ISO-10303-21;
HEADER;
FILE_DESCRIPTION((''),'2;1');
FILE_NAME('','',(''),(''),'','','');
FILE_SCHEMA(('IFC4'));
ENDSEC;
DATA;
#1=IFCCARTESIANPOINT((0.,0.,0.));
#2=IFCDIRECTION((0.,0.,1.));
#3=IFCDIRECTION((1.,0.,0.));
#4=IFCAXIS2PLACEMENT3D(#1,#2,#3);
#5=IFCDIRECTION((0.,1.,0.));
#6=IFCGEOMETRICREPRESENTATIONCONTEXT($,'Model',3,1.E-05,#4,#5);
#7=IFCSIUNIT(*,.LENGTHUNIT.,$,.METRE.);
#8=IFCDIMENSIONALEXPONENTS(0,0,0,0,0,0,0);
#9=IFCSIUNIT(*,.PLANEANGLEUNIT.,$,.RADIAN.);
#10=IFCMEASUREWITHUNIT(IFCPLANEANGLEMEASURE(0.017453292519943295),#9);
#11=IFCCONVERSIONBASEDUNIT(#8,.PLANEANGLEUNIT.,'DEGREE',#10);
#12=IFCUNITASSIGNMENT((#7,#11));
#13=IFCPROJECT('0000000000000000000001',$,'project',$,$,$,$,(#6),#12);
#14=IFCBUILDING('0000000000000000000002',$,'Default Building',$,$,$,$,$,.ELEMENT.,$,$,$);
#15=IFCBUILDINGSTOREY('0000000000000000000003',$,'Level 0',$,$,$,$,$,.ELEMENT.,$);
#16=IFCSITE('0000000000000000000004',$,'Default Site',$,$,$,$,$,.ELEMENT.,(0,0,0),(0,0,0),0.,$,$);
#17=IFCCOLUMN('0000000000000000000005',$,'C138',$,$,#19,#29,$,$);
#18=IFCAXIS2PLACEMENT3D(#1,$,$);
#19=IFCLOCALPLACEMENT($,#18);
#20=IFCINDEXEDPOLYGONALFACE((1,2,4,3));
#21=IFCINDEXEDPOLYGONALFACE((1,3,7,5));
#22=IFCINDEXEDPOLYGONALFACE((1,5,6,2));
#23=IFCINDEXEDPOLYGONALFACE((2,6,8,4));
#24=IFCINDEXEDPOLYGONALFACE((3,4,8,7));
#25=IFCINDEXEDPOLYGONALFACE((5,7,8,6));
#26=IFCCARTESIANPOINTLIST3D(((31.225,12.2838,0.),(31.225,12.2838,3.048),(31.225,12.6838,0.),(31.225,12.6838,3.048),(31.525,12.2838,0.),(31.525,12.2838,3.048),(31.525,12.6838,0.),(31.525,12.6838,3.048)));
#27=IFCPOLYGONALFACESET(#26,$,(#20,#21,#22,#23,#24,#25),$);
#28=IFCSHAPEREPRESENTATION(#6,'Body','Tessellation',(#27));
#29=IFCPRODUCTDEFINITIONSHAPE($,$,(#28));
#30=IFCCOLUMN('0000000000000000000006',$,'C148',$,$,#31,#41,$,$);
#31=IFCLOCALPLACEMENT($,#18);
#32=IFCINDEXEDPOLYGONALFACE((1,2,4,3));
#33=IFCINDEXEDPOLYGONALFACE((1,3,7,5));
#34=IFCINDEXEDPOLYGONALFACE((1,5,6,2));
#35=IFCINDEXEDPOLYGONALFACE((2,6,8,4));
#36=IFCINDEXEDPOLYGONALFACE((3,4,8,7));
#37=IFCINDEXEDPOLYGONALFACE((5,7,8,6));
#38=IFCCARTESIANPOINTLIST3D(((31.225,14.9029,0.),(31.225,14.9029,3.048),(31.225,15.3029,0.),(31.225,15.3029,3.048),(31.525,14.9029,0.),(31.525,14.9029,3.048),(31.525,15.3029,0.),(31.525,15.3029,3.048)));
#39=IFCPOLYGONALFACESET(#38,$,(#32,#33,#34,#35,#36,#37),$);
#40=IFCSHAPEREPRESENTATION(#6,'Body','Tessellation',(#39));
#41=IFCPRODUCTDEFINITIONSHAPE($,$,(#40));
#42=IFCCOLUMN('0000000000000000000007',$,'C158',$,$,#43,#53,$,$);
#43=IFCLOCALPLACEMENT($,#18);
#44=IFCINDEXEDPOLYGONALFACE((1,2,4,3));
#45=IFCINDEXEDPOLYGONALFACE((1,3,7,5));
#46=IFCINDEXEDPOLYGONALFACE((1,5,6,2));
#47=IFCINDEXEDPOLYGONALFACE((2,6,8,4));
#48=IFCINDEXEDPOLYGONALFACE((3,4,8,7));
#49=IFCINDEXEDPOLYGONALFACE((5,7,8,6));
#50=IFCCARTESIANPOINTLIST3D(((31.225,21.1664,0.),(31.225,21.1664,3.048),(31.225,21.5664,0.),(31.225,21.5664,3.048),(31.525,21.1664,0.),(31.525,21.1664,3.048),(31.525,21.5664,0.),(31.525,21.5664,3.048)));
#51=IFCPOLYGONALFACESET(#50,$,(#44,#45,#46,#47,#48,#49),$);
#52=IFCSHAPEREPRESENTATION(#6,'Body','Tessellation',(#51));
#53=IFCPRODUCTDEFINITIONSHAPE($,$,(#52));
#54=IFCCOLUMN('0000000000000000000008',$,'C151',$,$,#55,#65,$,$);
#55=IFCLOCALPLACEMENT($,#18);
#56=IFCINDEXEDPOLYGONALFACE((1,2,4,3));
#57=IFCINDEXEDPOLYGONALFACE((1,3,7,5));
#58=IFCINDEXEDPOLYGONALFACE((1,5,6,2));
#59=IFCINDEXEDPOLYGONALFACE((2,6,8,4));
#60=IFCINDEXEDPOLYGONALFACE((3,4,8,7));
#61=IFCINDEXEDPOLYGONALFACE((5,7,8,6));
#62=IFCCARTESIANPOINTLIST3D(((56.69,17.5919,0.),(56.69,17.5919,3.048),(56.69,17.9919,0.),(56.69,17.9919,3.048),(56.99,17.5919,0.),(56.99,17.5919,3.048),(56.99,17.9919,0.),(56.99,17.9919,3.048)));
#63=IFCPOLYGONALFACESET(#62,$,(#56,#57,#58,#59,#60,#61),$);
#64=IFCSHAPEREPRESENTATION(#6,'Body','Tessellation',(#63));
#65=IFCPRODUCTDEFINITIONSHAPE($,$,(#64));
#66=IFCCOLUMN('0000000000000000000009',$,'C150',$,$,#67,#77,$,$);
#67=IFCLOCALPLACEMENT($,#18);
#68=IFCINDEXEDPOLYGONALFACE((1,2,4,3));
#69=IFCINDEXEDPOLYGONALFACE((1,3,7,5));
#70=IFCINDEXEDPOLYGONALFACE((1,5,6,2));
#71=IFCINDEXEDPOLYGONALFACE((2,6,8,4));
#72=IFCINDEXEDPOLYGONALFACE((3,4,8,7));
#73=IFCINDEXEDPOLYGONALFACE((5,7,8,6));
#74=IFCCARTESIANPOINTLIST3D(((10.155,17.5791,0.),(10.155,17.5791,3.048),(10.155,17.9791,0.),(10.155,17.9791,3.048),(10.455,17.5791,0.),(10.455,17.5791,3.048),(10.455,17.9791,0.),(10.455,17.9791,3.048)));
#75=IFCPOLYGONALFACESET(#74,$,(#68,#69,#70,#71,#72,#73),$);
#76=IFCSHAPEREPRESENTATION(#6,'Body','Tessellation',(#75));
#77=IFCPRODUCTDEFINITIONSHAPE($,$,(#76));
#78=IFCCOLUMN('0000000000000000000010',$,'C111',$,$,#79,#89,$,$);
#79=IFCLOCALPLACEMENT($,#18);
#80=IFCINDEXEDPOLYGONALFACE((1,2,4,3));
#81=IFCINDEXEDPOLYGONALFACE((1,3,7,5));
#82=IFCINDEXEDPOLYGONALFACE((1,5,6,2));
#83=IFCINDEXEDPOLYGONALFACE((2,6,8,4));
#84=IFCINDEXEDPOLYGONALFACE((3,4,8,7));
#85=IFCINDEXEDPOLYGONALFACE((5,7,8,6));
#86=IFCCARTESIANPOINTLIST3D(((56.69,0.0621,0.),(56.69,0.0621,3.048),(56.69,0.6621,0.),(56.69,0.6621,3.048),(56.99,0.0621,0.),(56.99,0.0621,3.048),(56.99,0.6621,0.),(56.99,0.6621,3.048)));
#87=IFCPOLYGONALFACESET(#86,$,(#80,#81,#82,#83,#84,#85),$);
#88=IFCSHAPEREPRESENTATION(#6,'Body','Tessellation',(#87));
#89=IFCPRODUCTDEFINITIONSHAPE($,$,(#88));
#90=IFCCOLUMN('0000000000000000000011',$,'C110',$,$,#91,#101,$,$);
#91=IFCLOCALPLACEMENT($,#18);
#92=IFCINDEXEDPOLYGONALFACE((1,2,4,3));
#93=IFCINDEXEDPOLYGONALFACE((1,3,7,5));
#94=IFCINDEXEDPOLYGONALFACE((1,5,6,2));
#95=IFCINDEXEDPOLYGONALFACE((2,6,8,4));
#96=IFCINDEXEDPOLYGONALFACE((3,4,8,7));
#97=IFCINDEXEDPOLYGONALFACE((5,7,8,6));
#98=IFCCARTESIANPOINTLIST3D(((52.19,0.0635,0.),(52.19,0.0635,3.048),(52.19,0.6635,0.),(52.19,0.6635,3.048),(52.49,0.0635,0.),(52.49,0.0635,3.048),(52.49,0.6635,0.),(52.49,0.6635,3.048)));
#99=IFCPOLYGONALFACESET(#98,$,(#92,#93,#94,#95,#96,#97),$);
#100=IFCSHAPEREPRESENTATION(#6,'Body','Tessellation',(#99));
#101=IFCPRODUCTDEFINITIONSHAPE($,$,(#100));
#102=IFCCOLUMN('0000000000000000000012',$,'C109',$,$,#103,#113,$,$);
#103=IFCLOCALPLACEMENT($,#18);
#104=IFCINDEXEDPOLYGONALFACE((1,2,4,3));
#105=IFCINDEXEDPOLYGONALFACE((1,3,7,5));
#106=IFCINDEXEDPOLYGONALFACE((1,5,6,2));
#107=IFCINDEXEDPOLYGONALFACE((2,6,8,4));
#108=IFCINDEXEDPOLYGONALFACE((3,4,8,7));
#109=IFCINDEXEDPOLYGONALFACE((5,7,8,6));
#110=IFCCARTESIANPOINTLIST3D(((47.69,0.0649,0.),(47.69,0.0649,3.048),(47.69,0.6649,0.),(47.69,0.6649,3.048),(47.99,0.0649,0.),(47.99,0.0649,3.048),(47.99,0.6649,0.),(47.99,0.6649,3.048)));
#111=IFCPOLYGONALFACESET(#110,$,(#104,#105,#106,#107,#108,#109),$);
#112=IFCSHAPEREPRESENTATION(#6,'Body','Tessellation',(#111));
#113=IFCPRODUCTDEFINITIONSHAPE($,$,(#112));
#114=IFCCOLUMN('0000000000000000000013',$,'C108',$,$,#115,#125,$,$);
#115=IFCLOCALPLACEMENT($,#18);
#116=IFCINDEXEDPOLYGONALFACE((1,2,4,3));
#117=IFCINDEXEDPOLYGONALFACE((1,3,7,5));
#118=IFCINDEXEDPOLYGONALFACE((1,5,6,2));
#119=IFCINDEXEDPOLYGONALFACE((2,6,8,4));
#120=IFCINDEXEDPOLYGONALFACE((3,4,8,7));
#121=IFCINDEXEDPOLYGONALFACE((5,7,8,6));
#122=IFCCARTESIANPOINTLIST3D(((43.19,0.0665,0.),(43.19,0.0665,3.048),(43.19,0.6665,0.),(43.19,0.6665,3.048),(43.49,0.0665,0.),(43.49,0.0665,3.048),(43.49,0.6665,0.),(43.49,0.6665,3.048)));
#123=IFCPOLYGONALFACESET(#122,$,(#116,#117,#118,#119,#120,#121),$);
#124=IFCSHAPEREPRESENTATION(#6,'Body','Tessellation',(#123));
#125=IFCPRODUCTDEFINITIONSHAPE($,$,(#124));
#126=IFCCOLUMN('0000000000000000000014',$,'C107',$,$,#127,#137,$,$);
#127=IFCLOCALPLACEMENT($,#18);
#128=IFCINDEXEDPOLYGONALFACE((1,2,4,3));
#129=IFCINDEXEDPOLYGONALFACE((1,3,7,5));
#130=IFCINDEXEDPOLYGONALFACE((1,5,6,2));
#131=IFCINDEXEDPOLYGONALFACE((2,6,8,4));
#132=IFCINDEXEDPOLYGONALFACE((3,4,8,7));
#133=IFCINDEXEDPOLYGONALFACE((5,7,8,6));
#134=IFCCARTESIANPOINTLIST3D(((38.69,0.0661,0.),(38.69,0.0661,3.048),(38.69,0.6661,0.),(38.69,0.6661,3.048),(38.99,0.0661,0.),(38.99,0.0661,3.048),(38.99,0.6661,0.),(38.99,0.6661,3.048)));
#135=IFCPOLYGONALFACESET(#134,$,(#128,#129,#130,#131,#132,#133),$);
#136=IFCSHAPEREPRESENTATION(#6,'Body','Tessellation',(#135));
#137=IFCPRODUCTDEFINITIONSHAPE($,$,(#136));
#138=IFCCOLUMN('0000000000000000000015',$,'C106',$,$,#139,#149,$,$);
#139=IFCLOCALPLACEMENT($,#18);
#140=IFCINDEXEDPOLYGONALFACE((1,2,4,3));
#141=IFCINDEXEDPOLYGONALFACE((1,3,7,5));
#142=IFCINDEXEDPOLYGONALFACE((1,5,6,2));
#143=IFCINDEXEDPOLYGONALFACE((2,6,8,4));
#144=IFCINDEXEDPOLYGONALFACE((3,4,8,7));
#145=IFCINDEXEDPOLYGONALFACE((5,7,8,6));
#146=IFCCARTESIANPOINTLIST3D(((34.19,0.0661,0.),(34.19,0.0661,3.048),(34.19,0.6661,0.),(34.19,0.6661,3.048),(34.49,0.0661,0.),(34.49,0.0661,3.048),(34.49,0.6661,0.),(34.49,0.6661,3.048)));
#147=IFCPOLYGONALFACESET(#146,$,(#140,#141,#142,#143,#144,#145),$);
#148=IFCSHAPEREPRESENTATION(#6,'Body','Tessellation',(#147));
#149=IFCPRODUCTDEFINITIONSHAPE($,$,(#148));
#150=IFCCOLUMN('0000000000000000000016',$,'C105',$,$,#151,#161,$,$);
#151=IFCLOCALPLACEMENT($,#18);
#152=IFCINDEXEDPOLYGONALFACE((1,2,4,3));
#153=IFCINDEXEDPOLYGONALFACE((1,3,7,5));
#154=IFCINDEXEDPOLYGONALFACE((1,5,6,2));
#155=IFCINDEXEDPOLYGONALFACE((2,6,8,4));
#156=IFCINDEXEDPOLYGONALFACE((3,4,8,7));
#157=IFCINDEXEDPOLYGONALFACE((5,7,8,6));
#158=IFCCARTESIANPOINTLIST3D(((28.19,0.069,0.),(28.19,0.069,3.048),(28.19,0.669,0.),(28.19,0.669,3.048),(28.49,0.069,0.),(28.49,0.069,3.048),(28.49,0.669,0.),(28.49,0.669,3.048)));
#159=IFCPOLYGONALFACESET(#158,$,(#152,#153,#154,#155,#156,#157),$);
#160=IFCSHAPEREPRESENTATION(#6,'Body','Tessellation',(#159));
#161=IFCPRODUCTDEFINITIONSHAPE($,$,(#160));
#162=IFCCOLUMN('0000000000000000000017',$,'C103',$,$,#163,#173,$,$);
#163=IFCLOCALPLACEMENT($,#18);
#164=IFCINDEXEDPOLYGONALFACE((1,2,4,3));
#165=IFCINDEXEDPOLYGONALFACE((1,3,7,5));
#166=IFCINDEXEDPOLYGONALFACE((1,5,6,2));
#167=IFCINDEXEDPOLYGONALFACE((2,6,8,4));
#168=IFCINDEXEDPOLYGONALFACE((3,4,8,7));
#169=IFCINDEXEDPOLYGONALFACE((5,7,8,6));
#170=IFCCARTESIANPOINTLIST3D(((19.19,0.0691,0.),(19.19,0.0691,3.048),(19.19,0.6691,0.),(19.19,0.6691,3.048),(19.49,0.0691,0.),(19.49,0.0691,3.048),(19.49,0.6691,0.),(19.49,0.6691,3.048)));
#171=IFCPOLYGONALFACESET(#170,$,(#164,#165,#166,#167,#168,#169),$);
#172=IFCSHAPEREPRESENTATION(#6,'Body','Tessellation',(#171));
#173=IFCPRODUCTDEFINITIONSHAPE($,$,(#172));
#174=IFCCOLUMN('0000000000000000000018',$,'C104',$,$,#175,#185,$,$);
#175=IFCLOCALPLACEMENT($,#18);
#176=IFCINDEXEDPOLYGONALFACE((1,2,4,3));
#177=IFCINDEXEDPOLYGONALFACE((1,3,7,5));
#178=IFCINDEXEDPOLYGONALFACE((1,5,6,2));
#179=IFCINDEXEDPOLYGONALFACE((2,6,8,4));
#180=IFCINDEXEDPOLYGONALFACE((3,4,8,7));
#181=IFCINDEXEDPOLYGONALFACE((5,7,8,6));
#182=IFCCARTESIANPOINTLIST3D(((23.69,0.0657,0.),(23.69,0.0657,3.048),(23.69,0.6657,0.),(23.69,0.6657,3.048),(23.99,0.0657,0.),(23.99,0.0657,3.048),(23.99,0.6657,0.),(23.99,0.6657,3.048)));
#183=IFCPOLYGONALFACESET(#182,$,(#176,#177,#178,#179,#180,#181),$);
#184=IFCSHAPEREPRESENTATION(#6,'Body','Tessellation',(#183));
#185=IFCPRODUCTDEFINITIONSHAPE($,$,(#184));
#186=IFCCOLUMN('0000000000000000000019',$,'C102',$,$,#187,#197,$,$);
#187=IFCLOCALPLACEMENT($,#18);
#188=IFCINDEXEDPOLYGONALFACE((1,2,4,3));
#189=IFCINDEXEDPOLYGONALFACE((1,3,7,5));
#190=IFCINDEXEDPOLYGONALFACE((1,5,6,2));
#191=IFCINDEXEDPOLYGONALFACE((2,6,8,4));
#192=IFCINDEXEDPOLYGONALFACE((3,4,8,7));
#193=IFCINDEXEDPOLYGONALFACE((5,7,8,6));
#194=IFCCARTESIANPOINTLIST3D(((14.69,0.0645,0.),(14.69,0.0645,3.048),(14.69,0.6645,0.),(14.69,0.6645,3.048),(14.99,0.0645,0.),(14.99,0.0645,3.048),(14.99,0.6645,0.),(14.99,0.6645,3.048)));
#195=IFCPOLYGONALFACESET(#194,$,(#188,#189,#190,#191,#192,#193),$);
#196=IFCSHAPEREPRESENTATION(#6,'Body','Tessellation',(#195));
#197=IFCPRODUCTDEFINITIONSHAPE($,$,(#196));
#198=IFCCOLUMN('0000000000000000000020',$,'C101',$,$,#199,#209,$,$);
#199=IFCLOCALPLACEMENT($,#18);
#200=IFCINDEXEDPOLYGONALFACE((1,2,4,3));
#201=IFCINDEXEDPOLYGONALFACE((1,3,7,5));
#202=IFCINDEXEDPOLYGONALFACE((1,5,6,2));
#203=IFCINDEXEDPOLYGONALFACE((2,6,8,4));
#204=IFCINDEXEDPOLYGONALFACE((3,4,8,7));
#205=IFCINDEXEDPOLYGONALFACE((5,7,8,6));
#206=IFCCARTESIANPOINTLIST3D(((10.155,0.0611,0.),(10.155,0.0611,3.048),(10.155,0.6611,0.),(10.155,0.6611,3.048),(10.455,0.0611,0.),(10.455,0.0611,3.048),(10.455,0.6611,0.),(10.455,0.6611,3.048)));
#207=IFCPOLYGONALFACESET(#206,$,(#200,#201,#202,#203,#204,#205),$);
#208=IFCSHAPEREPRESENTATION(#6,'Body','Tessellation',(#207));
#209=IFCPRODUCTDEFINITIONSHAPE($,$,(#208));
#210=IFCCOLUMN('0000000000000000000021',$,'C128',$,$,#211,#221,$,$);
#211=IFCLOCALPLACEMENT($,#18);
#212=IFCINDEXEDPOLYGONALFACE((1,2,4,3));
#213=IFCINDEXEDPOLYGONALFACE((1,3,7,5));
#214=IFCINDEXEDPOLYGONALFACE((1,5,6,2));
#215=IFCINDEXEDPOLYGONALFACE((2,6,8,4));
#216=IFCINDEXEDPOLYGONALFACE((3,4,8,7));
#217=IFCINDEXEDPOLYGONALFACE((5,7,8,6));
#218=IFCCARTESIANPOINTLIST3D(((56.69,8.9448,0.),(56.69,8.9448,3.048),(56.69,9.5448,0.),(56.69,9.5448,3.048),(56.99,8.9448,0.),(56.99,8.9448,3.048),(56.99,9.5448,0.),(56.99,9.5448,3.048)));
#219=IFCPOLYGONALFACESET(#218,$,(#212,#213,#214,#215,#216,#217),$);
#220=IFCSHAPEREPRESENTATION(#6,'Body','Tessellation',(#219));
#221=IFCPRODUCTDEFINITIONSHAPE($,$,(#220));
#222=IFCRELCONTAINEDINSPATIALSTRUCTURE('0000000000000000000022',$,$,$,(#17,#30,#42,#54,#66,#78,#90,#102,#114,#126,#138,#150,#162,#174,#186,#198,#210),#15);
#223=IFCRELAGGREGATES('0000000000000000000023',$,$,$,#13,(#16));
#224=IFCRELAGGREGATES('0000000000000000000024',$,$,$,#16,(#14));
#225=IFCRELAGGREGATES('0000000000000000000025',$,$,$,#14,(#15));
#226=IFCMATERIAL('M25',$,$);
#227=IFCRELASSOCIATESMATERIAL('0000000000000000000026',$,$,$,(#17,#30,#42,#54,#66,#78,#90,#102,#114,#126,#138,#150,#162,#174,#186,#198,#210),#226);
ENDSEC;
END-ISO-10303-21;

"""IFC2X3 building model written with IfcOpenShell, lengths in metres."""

from ifc_helpers import new_model, entity, si_unit, converted_unit, direction, frame, frame_2d, origin_with_axes, place, context, project, spatial, rectangle, extrude, material, element, save


model = new_model("IFC2X3")

# Units and contexts
model_context = context("Model", 3, precision=1e-05, world=origin_with_axes(), true_north=direction((0.0, 1.0, 0.0)))
ifc_project = project(units=[si_unit("LENGTHUNIT", "METRE"), converted_unit("PLANEANGLEUNIT", "DEGREE", entity("IfcPlaneAngleMeasure", 0.017453292519943295), si_unit("PLANEANGLEUNIT", "RADIAN"), dimensions=[0, 0, 0, 0, 0, 0, 0])], contexts=[model_context])

# Site, building, storey
site = spatial("IfcSite", under=ifc_project, Name="Default Site", CompositionType="ELEMENT", RefLatitude=(0, 0, 0), RefLongitude=(0, 0, 0), RefElevation=0.0)
building = spatial("IfcBuilding", under=site, Name="Default Building", CompositionType="ELEMENT")
storey = spatial("IfcBuildingStorey", under=building, Name="Level 0", CompositionType="ELEMENT")

# Columns
ifc_material = material(Name="M25")
placement = place(None, origin_with_axes())
element("IfcColumn", 1, at=placement, inside=storey, material=ifc_material, Name="C138", context=model_context, shape_type="SweptSolid", body=[
    extrude(rectangle(XDim=0.3, YDim=0.4, at=frame_2d((0.0, 0.0), x_axis=(1.0, 0.0, 0.0))), frame((31.375, 12.4838, 0.0), z_axis=(0.0, 0.0, 1.0), x_axis=(1.0, 0.0, 0.0)), (0.0, 0.0, 1.0), 3.048),
])
element("IfcColumn", 2, at=placement, inside=storey, material=ifc_material, Name="C148", context=model_context, shape_type="SweptSolid", body=[
    extrude(rectangle(XDim=0.3, YDim=0.4, at=frame_2d((0.0, 0.0), x_axis=(1.0, 0.0, 0.0))), frame((31.375, 15.1029, 0.0), z_axis=(0.0, 0.0, 1.0), x_axis=(1.0, 0.0, 0.0)), (0.0, 0.0, 1.0), 3.048),
])
element("IfcColumn", 3, at=placement, inside=storey, material=ifc_material, Name="C158", context=model_context, shape_type="SweptSolid", body=[
    extrude(rectangle(XDim=0.3, YDim=0.4, at=frame_2d((0.0, 0.0), x_axis=(1.0, 0.0, 0.0))), frame((31.375, 21.3664, 0.0), z_axis=(0.0, 0.0, 1.0), x_axis=(1.0, 0.0, 0.0)), (0.0, 0.0, 1.0), 3.048),
])
element("IfcColumn", 4, at=placement, inside=storey, material=ifc_material, Name="C151", context=model_context, shape_type="SweptSolid", body=[
    extrude(rectangle(XDim=0.3, YDim=0.4, at=frame_2d((0.0, 0.0), x_axis=(1.0, 0.0, 0.0))), frame((56.84, 17.7919, 0.0), z_axis=(0.0, 0.0, 1.0), x_axis=(1.0, 0.0, 0.0)), (0.0, 0.0, 1.0), 3.048),
])
element("IfcColumn", 5, at=placement, inside=storey, material=ifc_material, Name="C150", context=model_context, shape_type="SweptSolid", body=[
    extrude(rectangle(XDim=0.3, YDim=0.4, at=frame_2d((0.0, 0.0), x_axis=(1.0, 0.0, 0.0))), frame((10.305, 17.7791, 0.0), z_axis=(0.0, 0.0, 1.0), x_axis=(1.0, 0.0, 0.0)), (0.0, 0.0, 1.0), 3.048),
])
element("IfcColumn", 6, at=placement, inside=storey, material=ifc_material, Name="C111", context=model_context, shape_type="SweptSolid", body=[
    extrude(rectangle(XDim=0.3, YDim=0.6, at=frame_2d((0.0, 0.0), x_axis=(1.0, 0.0, 0.0))), frame((56.84, 0.3621, 0.0), z_axis=(0.0, 0.0, 1.0), x_axis=(1.0, 0.0, 0.0)), (0.0, 0.0, 1.0), 3.048),
])
element("IfcColumn", 7, at=placement, inside=storey, material=ifc_material, Name="C110", context=model_context, shape_type="SweptSolid", body=[
    extrude(rectangle(XDim=0.3, YDim=0.6, at=frame_2d((0.0, 0.0), x_axis=(1.0, 0.0, 0.0))), frame((52.34, 0.3635, 0.0), z_axis=(0.0, 0.0, 1.0), x_axis=(1.0, 0.0, 0.0)), (0.0, 0.0, 1.0), 3.048),
])
element("IfcColumn", 8, at=placement, inside=storey, material=ifc_material, Name="C109", context=model_context, shape_type="SweptSolid", body=[
    extrude(rectangle(XDim=0.3, YDim=0.6, at=frame_2d((0.0, 0.0), x_axis=(1.0, 0.0, 0.0))), frame((47.84, 0.3649, 0.0), z_axis=(0.0, 0.0, 1.0), x_axis=(1.0, 0.0, 0.0)), (0.0, 0.0, 1.0), 3.048),
])
element("IfcColumn", 9, at=placement, inside=storey, material=ifc_material, Name="C108", context=model_context, shape_type="SweptSolid", body=[
    extrude(rectangle(XDim=0.3, YDim=0.6, at=frame_2d((0.0, 0.0), x_axis=(1.0, 0.0, 0.0))), frame((43.34, 0.3665, 0.0), z_axis=(0.0, 0.0, 1.0), x_axis=(1.0, 0.0, 0.0)), (0.0, 0.0, 1.0), 3.048),
])
element("IfcColumn", 10, at=placement, inside=storey, material=ifc_material, Name="C107", context=model_context, shape_type="SweptSolid", body=[
    extrude(rectangle(XDim=0.3, YDim=0.6, at=frame_2d((0.0, 0.0), x_axis=(1.0, 0.0, 0.0))), frame((38.84, 0.3661, 0.0), z_axis=(0.0, 0.0, 1.0), x_axis=(1.0, 0.0, 0.0)), (0.0, 0.0, 1.0), 3.048),
])
element("IfcColumn", 11, at=placement, inside=storey, material=ifc_material, Name="C106", context=model_context, shape_type="SweptSolid", body=[
    extrude(rectangle(XDim=0.3, YDim=0.6, at=frame_2d((0.0, 0.0), x_axis=(1.0, 0.0, 0.0))), frame((34.34, 0.3661, 0.0), z_axis=(0.0, 0.0, 1.0), x_axis=(1.0, 0.0, 0.0)), (0.0, 0.0, 1.0), 3.048),
])
element("IfcColumn", 12, at=placement, inside=storey, material=ifc_material, Name="C105", context=model_context, shape_type="SweptSolid", body=[
    extrude(rectangle(XDim=0.3, YDim=0.6, at=frame_2d((0.0, 0.0), x_axis=(1.0, 0.0, 0.0))), frame((28.34, 0.369, 0.0), z_axis=(0.0, 0.0, 1.0), x_axis=(1.0, 0.0, 0.0)), (0.0, 0.0, 1.0), 3.048),
])
element("IfcColumn", 13, at=placement, inside=storey, material=ifc_material, Name="C103", context=model_context, shape_type="SweptSolid", body=[
    extrude(rectangle(XDim=0.3, YDim=0.6, at=frame_2d((0.0, 0.0), x_axis=(1.0, 0.0, 0.0))), frame((19.34, 0.3691, 0.0), z_axis=(0.0, 0.0, 1.0), x_axis=(1.0, 0.0, 0.0)), (0.0, 0.0, 1.0), 3.048),
])
element("IfcColumn", 14, at=placement, inside=storey, material=ifc_material, Name="C104", context=model_context, shape_type="SweptSolid", body=[
    extrude(rectangle(XDim=0.3, YDim=0.6, at=frame_2d((0.0, 0.0), x_axis=(1.0, 0.0, 0.0))), frame((23.84, 0.3657, 0.0), z_axis=(0.0, 0.0, 1.0), x_axis=(1.0, 0.0, 0.0)), (0.0, 0.0, 1.0), 3.048),
])
element("IfcColumn", 15, at=placement, inside=storey, material=ifc_material, Name="C102", context=model_context, shape_type="SweptSolid", body=[
    extrude(rectangle(XDim=0.3, YDim=0.6, at=frame_2d((0.0, 0.0), x_axis=(1.0, 0.0, 0.0))), frame((14.84, 0.3645, 0.0), z_axis=(0.0, 0.0, 1.0), x_axis=(1.0, 0.0, 0.0)), (0.0, 0.0, 1.0), 3.048),
])
element("IfcColumn", 16, at=placement, inside=storey, material=ifc_material, Name="C101", context=model_context, shape_type="SweptSolid", body=[
    extrude(rectangle(XDim=0.3, YDim=0.6, at=frame_2d((0.0, 0.0), x_axis=(1.0, 0.0, 0.0))), frame((10.305, 0.3611, 0.0), z_axis=(0.0, 0.0, 1.0), x_axis=(1.0, 0.0, 0.0)), (0.0, 0.0, 1.0), 3.048),
])
element("IfcColumn", 17, at=placement, inside=storey, material=ifc_material, Name="C128", context=model_context, shape_type="SweptSolid", body=[
    extrude(rectangle(XDim=0.3, YDim=0.6, at=frame_2d((0.0, 0.0), x_axis=(1.0, 0.0, 0.0))), frame((56.84, 9.2448, 0.0), z_axis=(0.0, 0.0, 1.0), x_axis=(1.0, 0.0, 0.0)), (0.0, 0.0, 1.0), 3.048),
])

save(model, "model.ifc")
